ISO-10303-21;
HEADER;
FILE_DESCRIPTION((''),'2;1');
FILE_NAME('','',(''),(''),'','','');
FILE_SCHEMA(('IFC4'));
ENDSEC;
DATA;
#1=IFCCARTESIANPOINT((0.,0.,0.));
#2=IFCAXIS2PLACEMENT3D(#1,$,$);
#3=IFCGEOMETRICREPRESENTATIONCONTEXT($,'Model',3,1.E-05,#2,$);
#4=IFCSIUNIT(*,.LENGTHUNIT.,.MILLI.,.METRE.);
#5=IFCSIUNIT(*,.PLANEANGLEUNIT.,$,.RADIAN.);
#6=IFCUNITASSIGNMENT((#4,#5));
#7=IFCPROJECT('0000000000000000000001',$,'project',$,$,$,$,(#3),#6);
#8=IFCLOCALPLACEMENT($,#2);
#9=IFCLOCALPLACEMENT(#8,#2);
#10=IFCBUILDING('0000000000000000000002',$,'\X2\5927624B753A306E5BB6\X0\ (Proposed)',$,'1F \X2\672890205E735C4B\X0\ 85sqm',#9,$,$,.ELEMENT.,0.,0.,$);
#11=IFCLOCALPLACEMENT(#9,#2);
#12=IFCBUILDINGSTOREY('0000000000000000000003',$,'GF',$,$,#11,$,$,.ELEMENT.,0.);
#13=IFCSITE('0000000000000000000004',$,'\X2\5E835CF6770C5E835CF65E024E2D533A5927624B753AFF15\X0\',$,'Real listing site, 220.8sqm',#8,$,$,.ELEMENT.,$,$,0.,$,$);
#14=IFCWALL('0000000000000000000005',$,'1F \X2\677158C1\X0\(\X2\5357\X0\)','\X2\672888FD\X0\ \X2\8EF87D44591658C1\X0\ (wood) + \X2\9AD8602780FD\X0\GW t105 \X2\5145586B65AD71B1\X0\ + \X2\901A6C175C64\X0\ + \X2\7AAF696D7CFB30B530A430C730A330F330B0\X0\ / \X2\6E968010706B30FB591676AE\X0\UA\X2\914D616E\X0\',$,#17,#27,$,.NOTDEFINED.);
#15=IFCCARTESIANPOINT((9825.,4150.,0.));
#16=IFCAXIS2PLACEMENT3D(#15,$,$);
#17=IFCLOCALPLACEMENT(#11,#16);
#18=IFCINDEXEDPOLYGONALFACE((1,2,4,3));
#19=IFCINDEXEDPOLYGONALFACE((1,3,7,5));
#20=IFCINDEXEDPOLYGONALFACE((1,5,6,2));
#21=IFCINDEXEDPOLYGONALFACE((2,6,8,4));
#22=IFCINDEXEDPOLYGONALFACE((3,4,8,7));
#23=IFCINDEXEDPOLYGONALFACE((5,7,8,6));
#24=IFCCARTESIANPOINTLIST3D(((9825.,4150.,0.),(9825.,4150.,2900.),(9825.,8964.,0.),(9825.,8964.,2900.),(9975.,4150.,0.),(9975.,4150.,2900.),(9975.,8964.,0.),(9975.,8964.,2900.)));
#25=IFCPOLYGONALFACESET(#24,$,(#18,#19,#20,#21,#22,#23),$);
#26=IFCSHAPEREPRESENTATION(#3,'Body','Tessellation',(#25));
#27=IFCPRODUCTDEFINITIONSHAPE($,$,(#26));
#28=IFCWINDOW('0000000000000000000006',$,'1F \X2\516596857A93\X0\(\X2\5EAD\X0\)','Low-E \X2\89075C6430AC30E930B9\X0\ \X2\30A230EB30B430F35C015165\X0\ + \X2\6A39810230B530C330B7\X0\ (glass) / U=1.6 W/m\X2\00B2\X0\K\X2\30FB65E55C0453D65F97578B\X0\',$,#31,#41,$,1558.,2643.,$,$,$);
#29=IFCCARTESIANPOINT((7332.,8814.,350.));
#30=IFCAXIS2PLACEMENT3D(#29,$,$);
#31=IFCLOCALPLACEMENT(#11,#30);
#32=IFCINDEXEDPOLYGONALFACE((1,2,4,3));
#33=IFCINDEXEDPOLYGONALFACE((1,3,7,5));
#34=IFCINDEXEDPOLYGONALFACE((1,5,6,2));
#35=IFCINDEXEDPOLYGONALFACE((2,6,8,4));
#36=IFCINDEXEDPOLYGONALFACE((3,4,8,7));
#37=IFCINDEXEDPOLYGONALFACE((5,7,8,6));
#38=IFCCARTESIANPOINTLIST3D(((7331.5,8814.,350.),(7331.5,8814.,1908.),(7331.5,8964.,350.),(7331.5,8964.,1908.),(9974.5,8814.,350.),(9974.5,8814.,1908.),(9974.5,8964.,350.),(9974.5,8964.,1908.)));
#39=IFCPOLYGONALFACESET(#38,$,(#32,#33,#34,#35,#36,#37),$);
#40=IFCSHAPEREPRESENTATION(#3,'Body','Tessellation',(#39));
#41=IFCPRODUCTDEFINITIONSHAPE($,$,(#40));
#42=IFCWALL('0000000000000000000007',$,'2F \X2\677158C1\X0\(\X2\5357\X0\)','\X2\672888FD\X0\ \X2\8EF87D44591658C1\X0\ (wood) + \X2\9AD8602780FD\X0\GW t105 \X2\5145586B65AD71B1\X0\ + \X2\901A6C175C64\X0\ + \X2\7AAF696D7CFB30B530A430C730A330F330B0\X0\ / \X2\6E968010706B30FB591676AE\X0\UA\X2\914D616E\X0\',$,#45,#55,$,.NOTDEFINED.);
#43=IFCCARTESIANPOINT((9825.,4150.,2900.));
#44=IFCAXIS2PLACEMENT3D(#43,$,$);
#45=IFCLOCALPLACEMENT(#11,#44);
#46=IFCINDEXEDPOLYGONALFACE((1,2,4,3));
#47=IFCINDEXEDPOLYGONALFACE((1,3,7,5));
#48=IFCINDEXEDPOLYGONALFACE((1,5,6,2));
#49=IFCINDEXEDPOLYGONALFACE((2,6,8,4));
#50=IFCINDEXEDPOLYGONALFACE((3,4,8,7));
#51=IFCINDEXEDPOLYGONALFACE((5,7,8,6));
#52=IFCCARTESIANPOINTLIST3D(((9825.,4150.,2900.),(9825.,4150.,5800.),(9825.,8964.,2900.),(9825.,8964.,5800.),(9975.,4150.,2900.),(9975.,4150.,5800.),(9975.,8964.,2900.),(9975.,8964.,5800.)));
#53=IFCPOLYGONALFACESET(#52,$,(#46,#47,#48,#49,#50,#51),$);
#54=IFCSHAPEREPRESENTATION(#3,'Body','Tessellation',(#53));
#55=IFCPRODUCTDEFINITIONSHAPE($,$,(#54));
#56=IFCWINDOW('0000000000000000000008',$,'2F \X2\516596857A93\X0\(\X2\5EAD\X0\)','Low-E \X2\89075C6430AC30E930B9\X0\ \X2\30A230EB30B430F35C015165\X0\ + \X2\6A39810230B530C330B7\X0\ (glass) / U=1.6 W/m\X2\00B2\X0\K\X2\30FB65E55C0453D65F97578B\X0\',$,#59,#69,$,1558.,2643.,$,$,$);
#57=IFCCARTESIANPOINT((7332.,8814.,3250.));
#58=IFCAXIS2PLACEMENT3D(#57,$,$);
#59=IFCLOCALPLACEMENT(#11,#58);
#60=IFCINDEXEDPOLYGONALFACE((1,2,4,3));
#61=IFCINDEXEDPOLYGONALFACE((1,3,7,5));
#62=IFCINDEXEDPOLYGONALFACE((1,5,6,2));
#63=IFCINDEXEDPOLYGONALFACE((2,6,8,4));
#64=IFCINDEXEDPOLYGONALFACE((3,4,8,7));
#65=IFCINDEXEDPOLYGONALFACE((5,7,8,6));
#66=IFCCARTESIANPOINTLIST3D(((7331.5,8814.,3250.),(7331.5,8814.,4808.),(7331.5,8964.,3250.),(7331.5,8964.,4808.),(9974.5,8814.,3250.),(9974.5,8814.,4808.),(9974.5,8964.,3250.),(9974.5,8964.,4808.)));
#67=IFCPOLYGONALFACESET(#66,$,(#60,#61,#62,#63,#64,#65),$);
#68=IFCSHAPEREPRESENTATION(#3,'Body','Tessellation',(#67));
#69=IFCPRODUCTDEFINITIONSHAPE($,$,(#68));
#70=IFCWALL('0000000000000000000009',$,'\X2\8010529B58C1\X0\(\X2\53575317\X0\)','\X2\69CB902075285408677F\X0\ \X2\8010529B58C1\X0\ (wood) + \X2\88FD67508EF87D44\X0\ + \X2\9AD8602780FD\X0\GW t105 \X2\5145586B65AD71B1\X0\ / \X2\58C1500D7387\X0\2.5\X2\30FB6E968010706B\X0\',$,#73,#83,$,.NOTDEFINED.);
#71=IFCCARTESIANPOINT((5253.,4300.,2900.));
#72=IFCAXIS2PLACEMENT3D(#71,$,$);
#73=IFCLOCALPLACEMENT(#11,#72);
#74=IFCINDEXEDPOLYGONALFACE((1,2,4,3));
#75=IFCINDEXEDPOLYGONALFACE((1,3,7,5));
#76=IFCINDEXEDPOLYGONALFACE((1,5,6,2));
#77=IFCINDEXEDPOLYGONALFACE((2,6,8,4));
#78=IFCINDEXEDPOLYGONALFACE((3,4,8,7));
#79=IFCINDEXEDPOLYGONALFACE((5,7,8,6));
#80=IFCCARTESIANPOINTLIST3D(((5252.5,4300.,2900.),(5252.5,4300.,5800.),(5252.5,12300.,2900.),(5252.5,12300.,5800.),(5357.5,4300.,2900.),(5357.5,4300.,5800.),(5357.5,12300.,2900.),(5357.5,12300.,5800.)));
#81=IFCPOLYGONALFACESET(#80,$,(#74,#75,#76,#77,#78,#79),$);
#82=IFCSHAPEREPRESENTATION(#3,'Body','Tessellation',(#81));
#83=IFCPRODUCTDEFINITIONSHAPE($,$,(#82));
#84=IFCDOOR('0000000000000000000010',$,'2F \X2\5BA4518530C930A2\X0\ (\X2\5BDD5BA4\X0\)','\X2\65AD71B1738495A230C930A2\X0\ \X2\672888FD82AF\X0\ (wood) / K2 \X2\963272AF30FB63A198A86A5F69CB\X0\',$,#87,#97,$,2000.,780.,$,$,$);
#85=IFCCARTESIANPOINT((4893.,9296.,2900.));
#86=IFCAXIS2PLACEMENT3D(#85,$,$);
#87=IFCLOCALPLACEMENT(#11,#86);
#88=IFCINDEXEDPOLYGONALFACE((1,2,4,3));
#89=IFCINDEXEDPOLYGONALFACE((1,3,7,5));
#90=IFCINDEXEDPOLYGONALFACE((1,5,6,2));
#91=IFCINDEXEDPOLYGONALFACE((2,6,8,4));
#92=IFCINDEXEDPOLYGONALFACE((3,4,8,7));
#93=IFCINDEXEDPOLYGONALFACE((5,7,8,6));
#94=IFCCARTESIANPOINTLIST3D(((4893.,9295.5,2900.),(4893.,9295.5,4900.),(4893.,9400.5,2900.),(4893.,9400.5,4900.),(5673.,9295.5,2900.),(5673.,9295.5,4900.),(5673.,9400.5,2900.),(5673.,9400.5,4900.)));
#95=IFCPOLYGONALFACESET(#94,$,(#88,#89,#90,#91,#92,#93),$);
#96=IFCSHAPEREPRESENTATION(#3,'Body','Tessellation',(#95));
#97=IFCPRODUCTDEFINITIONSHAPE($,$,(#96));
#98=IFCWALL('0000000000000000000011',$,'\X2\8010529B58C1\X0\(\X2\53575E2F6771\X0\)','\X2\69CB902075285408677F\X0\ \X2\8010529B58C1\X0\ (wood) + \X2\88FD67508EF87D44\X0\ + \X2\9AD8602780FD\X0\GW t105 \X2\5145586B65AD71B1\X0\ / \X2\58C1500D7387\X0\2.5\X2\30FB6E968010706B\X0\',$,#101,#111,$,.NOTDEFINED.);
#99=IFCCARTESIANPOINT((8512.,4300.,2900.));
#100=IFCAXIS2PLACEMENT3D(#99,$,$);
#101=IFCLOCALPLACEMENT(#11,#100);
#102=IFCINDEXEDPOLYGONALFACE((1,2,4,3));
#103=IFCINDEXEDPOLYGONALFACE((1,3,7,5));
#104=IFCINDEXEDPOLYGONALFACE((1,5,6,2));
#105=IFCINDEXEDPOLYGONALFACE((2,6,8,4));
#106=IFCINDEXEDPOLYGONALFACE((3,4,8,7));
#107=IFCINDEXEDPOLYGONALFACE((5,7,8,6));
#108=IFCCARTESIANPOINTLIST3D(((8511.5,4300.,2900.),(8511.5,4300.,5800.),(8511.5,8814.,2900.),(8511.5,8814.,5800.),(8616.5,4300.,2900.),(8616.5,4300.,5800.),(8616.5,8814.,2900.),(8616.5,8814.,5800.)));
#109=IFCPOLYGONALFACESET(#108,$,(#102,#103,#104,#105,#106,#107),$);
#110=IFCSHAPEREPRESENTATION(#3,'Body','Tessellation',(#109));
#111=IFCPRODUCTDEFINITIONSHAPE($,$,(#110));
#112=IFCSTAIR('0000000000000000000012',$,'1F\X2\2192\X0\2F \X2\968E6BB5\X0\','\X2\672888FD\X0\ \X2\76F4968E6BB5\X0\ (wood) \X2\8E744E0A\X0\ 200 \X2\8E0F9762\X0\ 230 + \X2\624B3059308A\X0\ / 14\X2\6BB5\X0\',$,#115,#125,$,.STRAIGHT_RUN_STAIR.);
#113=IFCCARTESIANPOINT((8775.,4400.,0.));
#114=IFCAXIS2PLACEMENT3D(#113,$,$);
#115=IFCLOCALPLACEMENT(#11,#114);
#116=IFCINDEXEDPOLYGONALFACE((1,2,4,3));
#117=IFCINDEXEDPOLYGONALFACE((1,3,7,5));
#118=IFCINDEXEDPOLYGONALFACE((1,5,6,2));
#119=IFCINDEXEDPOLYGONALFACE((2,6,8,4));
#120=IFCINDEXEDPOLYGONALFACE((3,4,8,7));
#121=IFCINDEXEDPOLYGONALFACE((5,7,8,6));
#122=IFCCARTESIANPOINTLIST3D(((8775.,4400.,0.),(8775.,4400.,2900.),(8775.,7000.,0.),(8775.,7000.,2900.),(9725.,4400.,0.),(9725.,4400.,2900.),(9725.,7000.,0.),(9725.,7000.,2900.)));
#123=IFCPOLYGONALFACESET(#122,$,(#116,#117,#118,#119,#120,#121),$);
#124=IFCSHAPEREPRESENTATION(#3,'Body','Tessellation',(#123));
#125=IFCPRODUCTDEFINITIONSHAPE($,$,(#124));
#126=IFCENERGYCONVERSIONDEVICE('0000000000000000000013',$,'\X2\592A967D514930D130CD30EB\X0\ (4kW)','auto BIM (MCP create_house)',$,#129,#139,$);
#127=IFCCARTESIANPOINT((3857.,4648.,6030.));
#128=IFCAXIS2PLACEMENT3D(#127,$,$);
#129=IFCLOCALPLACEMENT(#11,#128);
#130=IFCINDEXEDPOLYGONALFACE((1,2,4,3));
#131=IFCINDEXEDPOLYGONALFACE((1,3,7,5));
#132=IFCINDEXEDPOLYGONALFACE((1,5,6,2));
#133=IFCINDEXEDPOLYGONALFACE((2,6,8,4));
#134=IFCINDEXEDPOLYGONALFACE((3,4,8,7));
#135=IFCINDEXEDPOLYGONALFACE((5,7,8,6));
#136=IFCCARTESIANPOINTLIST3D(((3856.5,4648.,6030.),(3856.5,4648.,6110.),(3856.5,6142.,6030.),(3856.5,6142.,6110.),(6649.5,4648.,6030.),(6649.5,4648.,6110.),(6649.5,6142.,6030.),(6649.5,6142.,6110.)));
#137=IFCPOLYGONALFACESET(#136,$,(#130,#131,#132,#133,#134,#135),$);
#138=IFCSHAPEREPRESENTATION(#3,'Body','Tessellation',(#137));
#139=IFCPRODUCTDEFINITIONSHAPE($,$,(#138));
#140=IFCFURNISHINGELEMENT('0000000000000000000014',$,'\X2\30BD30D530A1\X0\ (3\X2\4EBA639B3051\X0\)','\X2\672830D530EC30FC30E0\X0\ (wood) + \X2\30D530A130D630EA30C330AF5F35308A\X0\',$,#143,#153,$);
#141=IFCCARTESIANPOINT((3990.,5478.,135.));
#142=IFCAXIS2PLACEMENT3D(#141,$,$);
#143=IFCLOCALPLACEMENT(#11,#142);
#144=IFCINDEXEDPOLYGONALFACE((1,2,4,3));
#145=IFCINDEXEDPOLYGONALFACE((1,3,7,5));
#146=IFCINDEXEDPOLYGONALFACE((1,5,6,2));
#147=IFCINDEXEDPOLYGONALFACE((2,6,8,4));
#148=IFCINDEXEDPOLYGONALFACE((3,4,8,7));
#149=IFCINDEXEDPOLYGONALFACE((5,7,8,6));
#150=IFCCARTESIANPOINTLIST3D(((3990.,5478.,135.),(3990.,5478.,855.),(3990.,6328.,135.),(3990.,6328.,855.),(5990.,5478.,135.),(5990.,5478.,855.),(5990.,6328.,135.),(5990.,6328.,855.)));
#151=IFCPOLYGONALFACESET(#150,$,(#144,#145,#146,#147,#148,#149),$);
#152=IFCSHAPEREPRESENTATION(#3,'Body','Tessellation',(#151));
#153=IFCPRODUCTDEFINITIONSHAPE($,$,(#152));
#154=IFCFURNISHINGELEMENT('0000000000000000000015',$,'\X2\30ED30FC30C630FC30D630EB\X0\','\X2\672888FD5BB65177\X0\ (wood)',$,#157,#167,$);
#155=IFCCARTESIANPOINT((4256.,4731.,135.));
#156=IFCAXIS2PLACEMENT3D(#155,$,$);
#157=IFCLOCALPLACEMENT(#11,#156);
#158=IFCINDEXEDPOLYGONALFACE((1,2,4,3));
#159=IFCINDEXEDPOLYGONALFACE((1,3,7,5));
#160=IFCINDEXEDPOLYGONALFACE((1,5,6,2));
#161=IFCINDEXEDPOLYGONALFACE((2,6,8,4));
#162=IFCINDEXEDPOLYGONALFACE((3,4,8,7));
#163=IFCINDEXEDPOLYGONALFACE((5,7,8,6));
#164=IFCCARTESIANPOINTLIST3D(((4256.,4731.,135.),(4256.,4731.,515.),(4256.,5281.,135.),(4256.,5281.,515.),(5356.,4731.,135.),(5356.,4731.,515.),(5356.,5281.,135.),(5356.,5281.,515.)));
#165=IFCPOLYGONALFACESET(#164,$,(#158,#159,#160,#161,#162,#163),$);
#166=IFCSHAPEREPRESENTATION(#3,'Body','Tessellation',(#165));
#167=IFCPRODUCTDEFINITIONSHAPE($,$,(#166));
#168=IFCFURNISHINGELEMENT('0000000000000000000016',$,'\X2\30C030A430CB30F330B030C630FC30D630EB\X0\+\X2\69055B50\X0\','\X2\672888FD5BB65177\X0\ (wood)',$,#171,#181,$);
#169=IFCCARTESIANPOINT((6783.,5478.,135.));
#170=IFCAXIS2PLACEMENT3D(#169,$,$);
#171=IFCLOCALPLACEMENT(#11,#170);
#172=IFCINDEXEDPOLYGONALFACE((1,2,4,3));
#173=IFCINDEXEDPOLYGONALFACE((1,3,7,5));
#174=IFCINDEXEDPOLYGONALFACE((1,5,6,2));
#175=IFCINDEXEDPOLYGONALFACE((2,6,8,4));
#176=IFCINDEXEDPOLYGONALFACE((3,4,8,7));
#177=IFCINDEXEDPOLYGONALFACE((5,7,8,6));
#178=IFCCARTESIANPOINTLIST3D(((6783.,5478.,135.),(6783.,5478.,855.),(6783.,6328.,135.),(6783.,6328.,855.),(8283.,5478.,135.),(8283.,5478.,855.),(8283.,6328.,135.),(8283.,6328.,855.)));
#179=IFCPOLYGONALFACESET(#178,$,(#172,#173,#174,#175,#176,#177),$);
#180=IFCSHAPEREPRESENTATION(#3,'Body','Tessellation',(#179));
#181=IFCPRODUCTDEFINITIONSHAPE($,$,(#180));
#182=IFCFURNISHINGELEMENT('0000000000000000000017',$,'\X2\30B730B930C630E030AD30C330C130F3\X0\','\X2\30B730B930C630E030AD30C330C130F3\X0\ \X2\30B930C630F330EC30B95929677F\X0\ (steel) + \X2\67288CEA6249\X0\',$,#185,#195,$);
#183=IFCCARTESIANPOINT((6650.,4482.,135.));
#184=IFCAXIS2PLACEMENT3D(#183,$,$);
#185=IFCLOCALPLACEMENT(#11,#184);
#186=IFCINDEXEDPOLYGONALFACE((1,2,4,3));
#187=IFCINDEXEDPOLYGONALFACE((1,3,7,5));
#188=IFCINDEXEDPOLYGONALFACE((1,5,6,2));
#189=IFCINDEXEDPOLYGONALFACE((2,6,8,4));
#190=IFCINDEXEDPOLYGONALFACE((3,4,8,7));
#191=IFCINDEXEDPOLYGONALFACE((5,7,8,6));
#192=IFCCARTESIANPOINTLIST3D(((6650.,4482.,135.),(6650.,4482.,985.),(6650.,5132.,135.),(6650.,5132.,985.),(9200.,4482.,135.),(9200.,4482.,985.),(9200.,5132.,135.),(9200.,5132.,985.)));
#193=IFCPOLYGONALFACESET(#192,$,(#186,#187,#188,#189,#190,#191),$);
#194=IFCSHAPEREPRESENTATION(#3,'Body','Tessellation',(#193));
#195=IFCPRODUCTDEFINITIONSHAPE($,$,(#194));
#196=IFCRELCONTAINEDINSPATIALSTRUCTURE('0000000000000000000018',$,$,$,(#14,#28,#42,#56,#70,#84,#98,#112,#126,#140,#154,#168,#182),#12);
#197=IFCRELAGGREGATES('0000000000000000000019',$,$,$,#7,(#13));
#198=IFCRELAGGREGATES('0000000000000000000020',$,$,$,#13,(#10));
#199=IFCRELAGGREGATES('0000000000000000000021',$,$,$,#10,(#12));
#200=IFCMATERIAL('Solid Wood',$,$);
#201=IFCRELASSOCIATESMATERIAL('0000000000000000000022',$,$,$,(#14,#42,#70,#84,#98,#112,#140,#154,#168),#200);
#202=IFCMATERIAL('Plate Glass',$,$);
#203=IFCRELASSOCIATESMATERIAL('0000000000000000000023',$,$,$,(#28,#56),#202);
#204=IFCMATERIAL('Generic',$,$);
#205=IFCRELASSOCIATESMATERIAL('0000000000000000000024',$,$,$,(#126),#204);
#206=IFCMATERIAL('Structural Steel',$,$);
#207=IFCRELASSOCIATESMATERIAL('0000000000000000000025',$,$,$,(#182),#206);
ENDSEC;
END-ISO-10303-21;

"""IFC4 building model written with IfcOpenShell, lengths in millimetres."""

from ifc_helpers import new_model, si_unit, frame, frame_2d, origin, place, context, project, spatial, rectangle, extrude, material, element, fill, save


model = new_model("IFC4")

# Units and contexts
model_context = context("Model", 3, precision=1e-05, world=origin())
ifc_project = project(units=[si_unit("LENGTHUNIT", "METRE", prefix="MILLI"), si_unit("PLANEANGLEUNIT", "RADIAN")], contexts=[model_context])

# Site, building, storey
site_placement = place(None, origin())
site = spatial("IfcSite", under=ifc_project, at=site_placement, Name="広島県広島市中区大手町５", ObjectType="Real listing site, 220.8sqm", CompositionType="ELEMENT", RefElevation=0.0)
building_placement = place(site_placement, origin())
building = spatial("IfcBuilding", under=site, at=building_placement, Name="大手町の家 (Proposed)", ObjectType="1F 木造平屋 85sqm", CompositionType="ELEMENT", ElevationOfRefHeight=0.0, ElevationOfTerrain=0.0)
storey_placement = place(building_placement, origin())
storey = spatial("IfcBuildingStorey", under=building, at=storey_placement, Name="GF", CompositionType="ELEMENT", Elevation=0.0)

# Wall, opening, window
ifc_material_1 = material(Name="Solid Wood")
wall_1_placement = place(storey_placement, frame((9825.0, 4150.0, 0.0)))
wall_1 = element("IfcWall", 1, at=wall_1_placement, inside=storey, material=ifc_material_1, Name="1F 東壁(南)", Description="木製 軸組外壁 (wood) + 高性能GW t105 充填断熱 + 通気層 + 窯業系サイディング / 準耐火・外皮UA配慮", PredefinedType="NOTDEFINED", context=model_context, shape_type="SweptSolid", body=[
    extrude(rectangle(XDim=150.0, YDim=4814.0, at=frame_2d((75.0, 2407.0))), frame((9825.0, 4150.0, 0.0)), (0.0, 0.0, 1.0), 2900.0),
])
opening_1_placement = place(storey_placement, frame((7332.0, 8814.0, 350.0)))
opening_1 = element("IfcOpeningElement", 2, at=opening_1_placement, cuts=wall_1, PredefinedType="NOTDEFINED", context=model_context, shape_type="SweptSolid", body=[
    extrude(rectangle(XDim=2643.0, YDim=150.0, at=frame_2d((1321.0, 75.0))), frame((7332.0, 8814.0, 350.0)), (0.0, 0.0, 1.0), 1558.0),
])
ifc_material_2 = material(Name="Plate Glass")
window_1_placement = place(storey_placement, frame((7332.0, 8814.0, 350.0)))
window_1 = element("IfcWindow", 3, at=window_1_placement, inside=storey, material=ifc_material_2, Name="1F 入隅窓(庭)", Description="Low-E 複層ガラス アルゴン封入 + 樹脂サッシ (glass) / U=1.6 W/m²K・日射取得型", OverallHeight=1558.0, OverallWidth=2643.0, context=model_context, shape_type="SweptSolid", body=[
    extrude(rectangle(XDim=2643.0, YDim=150.0, at=frame_2d((1321.0, 75.0))), frame((7332.0, 8814.0, 350.0)), (0.0, 0.0, 1.0), 1558.0),
])
fill(opening_1, window_1)

# Wall, opening, window
wall_2_placement = place(storey_placement, frame((9825.0, 4150.0, 2900.0)))
wall_2 = element("IfcWall", 4, at=wall_2_placement, inside=storey, material=ifc_material_1, Name="2F 東壁(南)", Description="木製 軸組外壁 (wood) + 高性能GW t105 充填断熱 + 通気層 + 窯業系サイディング / 準耐火・外皮UA配慮", PredefinedType="NOTDEFINED", context=model_context, shape_type="SweptSolid", body=[
    extrude(rectangle(XDim=150.0, YDim=4814.0, at=frame_2d((75.0, 2407.0))), frame((9825.0, 4150.0, 2900.0)), (0.0, 0.0, 1.0), 2900.0),
])
opening_2_placement = place(storey_placement, frame((7332.0, 8814.0, 3250.0)))
opening_2 = element("IfcOpeningElement", 5, at=opening_2_placement, cuts=wall_2, PredefinedType="NOTDEFINED", context=model_context, shape_type="SweptSolid", body=[
    extrude(rectangle(XDim=2643.0, YDim=150.0, at=frame_2d((1321.0, 75.0))), frame((7332.0, 8814.0, 3250.0)), (0.0, 0.0, 1.0), 1558.0),
])
window_2_placement = place(storey_placement, frame((7332.0, 8814.0, 3250.0)))
window_2 = element("IfcWindow", 6, at=window_2_placement, inside=storey, material=ifc_material_2, Name="2F 入隅窓(庭)", Description="Low-E 複層ガラス アルゴン封入 + 樹脂サッシ (glass) / U=1.6 W/m²K・日射取得型", OverallHeight=1558.0, OverallWidth=2643.0, context=model_context, shape_type="SweptSolid", body=[
    extrude(rectangle(XDim=2643.0, YDim=150.0, at=frame_2d((1321.0, 75.0))), frame((7332.0, 8814.0, 3250.0)), (0.0, 0.0, 1.0), 1558.0),
])
fill(opening_2, window_2)

# Wall, opening, door
wall_3_placement = place(storey_placement, frame((5253.0, 4300.0, 2900.0)))
wall_3 = element("IfcWall", 7, at=wall_3_placement, inside=storey, material=ifc_material_1, Name="耐力壁(南北)", Description="構造用合板 耐力壁 (wood) + 製材軸組 + 高性能GW t105 充填断熱 / 壁倍率2.5・準耐火", PredefinedType="NOTDEFINED", context=model_context, shape_type="SweptSolid", body=[
    extrude(rectangle(XDim=105.0, YDim=8000.0, at=frame_2d((52.0, 4000.0))), frame((5253.0, 4300.0, 2900.0)), (0.0, 0.0, 1.0), 2900.0),
])
opening_3_placement = place(storey_placement, frame((4893.0, 9296.0, 2900.0)))
opening_3 = element("IfcOpeningElement", 8, at=opening_3_placement, cuts=wall_3, PredefinedType="NOTDEFINED", context=model_context, shape_type="SweptSolid", body=[
    extrude(rectangle(XDim=780.0, YDim=105.0, at=frame_2d((390.0, 52.0))), frame((4893.0, 9296.0, 2900.0)), (0.0, 0.0, 1.0), 2000.0),
])
door_1_placement = place(storey_placement, frame((4893.0, 9296.0, 2900.0)))
door_1 = element("IfcDoor", 9, at=door_1_placement, inside=storey, material=ifc_material_1, Name="2F 室内ドア (寝室)", Description="断熱玄関ドア 木製芯 (wood) / K2 防犯・採風機構", OverallHeight=2000.0, OverallWidth=780.0, context=model_context, shape_type="SweptSolid", body=[
    extrude(rectangle(XDim=780.0, YDim=105.0, at=frame_2d((390.0, 52.0))), frame((4893.0, 9296.0, 2900.0)), (0.0, 0.0, 1.0), 2000.0),
])
fill(opening_3, door_1)

# Wall
wall_4_placement = place(storey_placement, frame((8512.0, 4300.0, 2900.0)))
element("IfcWall", 10, at=wall_4_placement, inside=storey, material=ifc_material_1, Name="耐力壁(南帯東)", Description="構造用合板 耐力壁 (wood) + 製材軸組 + 高性能GW t105 充填断熱 / 壁倍率2.5・準耐火", PredefinedType="NOTDEFINED", context=model_context, shape_type="SweptSolid", body=[
    extrude(rectangle(XDim=105.0, YDim=4514.0, at=frame_2d((52.0, 2257.0))), frame((8512.0, 4300.0, 2900.0)), (0.0, 0.0, 1.0), 2900.0),
])

# Stair
stair_placement = place(storey_placement, frame((8775.0, 4400.0, 0.0)))
element("IfcStair", 11, at=stair_placement, inside=storey, material=ifc_material_1, Name="1F→2F 階段", Description="木製 直階段 (wood) 蹴上 200 踏面 230 + 手すり / 14段", PredefinedType="STRAIGHT_RUN_STAIR", context=model_context, shape_type="SweptSolid", body=[
    extrude(rectangle(XDim=950.0, YDim=2600.0, at=frame_2d((475.0, 1300.0))), frame((8775.0, 4400.0, 0.0)), (0.0, 0.0, 1.0), 2900.0),
])

# Energy conversion device
ifc_material_3 = material(Name="Generic")
energy_conversion_device_placement = place(storey_placement, frame((3857.0, 4648.0, 6030.0)))
element("IfcEnergyConversionDevice", 12, at=energy_conversion_device_placement, inside=storey, material=ifc_material_3, Name="太陽光パネル (4kW)", Description="auto BIM (MCP create_house)", context=model_context, shape_type="SweptSolid", body=[
    extrude(rectangle(XDim=2793.0, YDim=1494.0, at=frame_2d((1396.0, 747.0))), frame((3857.0, 4648.0, 6030.0)), (0.0, 0.0, 1.0), 80.0),
])

# Furnishing elements
furnishing_1_placement = place(storey_placement, frame((3990.0, 5478.0, 135.0)))
element("IfcFurnishingElement", 13, at=furnishing_1_placement, inside=storey, material=ifc_material_1, Name="ソファ (3人掛け)", Description="木フレーム (wood) + ファブリック張り", context=model_context, shape_type="SweptSolid", body=[
    extrude(rectangle(XDim=2000.0, YDim=850.0, at=frame_2d((1000.0, 425.0))), frame((3990.0, 5478.0, 135.0)), (0.0, 0.0, 1.0), 720.0),
])
furnishing_2_placement = place(storey_placement, frame((4256.0, 4731.0, 135.0)))
element("IfcFurnishingElement", 14, at=furnishing_2_placement, inside=storey, material=ifc_material_1, Name="ローテーブル", Description="木製家具 (wood)", context=model_context, shape_type="SweptSolid", body=[
    extrude(rectangle(XDim=1100.0, YDim=550.0, at=frame_2d((550.0, 275.0))), frame((4256.0, 4731.0, 135.0)), (0.0, 0.0, 1.0), 380.0),
])
furnishing_3_placement = place(storey_placement, frame((6783.0, 5478.0, 135.0)))
element("IfcFurnishingElement", 15, at=furnishing_3_placement, inside=storey, material=ifc_material_1, Name="ダイニングテーブル+椅子", Description="木製家具 (wood)", context=model_context, shape_type="SweptSolid", body=[
    extrude(rectangle(XDim=1500.0, YDim=850.0, at=frame_2d((750.0, 425.0))), frame((6783.0, 5478.0, 135.0)), (0.0, 0.0, 1.0), 720.0),
])
ifc_material_4 = material(Name="Structural Steel")
furnishing_4_placement = place(storey_placement, frame((6650.0, 4482.0, 135.0)))
element("IfcFurnishingElement", 16, at=furnishing_4_placement, inside=storey, material=ifc_material_4, Name="システムキッチン", Description="システムキッチン ステンレス天板 (steel) + 木質扉", context=model_context, shape_type="SweptSolid", body=[
    extrude(rectangle(XDim=2550.0, YDim=650.0, at=frame_2d((1275.0, 325.0))), frame((6650.0, 4482.0, 135.0)), (0.0, 0.0, 1.0), 850.0),
])

save(model, "model.ifc")
